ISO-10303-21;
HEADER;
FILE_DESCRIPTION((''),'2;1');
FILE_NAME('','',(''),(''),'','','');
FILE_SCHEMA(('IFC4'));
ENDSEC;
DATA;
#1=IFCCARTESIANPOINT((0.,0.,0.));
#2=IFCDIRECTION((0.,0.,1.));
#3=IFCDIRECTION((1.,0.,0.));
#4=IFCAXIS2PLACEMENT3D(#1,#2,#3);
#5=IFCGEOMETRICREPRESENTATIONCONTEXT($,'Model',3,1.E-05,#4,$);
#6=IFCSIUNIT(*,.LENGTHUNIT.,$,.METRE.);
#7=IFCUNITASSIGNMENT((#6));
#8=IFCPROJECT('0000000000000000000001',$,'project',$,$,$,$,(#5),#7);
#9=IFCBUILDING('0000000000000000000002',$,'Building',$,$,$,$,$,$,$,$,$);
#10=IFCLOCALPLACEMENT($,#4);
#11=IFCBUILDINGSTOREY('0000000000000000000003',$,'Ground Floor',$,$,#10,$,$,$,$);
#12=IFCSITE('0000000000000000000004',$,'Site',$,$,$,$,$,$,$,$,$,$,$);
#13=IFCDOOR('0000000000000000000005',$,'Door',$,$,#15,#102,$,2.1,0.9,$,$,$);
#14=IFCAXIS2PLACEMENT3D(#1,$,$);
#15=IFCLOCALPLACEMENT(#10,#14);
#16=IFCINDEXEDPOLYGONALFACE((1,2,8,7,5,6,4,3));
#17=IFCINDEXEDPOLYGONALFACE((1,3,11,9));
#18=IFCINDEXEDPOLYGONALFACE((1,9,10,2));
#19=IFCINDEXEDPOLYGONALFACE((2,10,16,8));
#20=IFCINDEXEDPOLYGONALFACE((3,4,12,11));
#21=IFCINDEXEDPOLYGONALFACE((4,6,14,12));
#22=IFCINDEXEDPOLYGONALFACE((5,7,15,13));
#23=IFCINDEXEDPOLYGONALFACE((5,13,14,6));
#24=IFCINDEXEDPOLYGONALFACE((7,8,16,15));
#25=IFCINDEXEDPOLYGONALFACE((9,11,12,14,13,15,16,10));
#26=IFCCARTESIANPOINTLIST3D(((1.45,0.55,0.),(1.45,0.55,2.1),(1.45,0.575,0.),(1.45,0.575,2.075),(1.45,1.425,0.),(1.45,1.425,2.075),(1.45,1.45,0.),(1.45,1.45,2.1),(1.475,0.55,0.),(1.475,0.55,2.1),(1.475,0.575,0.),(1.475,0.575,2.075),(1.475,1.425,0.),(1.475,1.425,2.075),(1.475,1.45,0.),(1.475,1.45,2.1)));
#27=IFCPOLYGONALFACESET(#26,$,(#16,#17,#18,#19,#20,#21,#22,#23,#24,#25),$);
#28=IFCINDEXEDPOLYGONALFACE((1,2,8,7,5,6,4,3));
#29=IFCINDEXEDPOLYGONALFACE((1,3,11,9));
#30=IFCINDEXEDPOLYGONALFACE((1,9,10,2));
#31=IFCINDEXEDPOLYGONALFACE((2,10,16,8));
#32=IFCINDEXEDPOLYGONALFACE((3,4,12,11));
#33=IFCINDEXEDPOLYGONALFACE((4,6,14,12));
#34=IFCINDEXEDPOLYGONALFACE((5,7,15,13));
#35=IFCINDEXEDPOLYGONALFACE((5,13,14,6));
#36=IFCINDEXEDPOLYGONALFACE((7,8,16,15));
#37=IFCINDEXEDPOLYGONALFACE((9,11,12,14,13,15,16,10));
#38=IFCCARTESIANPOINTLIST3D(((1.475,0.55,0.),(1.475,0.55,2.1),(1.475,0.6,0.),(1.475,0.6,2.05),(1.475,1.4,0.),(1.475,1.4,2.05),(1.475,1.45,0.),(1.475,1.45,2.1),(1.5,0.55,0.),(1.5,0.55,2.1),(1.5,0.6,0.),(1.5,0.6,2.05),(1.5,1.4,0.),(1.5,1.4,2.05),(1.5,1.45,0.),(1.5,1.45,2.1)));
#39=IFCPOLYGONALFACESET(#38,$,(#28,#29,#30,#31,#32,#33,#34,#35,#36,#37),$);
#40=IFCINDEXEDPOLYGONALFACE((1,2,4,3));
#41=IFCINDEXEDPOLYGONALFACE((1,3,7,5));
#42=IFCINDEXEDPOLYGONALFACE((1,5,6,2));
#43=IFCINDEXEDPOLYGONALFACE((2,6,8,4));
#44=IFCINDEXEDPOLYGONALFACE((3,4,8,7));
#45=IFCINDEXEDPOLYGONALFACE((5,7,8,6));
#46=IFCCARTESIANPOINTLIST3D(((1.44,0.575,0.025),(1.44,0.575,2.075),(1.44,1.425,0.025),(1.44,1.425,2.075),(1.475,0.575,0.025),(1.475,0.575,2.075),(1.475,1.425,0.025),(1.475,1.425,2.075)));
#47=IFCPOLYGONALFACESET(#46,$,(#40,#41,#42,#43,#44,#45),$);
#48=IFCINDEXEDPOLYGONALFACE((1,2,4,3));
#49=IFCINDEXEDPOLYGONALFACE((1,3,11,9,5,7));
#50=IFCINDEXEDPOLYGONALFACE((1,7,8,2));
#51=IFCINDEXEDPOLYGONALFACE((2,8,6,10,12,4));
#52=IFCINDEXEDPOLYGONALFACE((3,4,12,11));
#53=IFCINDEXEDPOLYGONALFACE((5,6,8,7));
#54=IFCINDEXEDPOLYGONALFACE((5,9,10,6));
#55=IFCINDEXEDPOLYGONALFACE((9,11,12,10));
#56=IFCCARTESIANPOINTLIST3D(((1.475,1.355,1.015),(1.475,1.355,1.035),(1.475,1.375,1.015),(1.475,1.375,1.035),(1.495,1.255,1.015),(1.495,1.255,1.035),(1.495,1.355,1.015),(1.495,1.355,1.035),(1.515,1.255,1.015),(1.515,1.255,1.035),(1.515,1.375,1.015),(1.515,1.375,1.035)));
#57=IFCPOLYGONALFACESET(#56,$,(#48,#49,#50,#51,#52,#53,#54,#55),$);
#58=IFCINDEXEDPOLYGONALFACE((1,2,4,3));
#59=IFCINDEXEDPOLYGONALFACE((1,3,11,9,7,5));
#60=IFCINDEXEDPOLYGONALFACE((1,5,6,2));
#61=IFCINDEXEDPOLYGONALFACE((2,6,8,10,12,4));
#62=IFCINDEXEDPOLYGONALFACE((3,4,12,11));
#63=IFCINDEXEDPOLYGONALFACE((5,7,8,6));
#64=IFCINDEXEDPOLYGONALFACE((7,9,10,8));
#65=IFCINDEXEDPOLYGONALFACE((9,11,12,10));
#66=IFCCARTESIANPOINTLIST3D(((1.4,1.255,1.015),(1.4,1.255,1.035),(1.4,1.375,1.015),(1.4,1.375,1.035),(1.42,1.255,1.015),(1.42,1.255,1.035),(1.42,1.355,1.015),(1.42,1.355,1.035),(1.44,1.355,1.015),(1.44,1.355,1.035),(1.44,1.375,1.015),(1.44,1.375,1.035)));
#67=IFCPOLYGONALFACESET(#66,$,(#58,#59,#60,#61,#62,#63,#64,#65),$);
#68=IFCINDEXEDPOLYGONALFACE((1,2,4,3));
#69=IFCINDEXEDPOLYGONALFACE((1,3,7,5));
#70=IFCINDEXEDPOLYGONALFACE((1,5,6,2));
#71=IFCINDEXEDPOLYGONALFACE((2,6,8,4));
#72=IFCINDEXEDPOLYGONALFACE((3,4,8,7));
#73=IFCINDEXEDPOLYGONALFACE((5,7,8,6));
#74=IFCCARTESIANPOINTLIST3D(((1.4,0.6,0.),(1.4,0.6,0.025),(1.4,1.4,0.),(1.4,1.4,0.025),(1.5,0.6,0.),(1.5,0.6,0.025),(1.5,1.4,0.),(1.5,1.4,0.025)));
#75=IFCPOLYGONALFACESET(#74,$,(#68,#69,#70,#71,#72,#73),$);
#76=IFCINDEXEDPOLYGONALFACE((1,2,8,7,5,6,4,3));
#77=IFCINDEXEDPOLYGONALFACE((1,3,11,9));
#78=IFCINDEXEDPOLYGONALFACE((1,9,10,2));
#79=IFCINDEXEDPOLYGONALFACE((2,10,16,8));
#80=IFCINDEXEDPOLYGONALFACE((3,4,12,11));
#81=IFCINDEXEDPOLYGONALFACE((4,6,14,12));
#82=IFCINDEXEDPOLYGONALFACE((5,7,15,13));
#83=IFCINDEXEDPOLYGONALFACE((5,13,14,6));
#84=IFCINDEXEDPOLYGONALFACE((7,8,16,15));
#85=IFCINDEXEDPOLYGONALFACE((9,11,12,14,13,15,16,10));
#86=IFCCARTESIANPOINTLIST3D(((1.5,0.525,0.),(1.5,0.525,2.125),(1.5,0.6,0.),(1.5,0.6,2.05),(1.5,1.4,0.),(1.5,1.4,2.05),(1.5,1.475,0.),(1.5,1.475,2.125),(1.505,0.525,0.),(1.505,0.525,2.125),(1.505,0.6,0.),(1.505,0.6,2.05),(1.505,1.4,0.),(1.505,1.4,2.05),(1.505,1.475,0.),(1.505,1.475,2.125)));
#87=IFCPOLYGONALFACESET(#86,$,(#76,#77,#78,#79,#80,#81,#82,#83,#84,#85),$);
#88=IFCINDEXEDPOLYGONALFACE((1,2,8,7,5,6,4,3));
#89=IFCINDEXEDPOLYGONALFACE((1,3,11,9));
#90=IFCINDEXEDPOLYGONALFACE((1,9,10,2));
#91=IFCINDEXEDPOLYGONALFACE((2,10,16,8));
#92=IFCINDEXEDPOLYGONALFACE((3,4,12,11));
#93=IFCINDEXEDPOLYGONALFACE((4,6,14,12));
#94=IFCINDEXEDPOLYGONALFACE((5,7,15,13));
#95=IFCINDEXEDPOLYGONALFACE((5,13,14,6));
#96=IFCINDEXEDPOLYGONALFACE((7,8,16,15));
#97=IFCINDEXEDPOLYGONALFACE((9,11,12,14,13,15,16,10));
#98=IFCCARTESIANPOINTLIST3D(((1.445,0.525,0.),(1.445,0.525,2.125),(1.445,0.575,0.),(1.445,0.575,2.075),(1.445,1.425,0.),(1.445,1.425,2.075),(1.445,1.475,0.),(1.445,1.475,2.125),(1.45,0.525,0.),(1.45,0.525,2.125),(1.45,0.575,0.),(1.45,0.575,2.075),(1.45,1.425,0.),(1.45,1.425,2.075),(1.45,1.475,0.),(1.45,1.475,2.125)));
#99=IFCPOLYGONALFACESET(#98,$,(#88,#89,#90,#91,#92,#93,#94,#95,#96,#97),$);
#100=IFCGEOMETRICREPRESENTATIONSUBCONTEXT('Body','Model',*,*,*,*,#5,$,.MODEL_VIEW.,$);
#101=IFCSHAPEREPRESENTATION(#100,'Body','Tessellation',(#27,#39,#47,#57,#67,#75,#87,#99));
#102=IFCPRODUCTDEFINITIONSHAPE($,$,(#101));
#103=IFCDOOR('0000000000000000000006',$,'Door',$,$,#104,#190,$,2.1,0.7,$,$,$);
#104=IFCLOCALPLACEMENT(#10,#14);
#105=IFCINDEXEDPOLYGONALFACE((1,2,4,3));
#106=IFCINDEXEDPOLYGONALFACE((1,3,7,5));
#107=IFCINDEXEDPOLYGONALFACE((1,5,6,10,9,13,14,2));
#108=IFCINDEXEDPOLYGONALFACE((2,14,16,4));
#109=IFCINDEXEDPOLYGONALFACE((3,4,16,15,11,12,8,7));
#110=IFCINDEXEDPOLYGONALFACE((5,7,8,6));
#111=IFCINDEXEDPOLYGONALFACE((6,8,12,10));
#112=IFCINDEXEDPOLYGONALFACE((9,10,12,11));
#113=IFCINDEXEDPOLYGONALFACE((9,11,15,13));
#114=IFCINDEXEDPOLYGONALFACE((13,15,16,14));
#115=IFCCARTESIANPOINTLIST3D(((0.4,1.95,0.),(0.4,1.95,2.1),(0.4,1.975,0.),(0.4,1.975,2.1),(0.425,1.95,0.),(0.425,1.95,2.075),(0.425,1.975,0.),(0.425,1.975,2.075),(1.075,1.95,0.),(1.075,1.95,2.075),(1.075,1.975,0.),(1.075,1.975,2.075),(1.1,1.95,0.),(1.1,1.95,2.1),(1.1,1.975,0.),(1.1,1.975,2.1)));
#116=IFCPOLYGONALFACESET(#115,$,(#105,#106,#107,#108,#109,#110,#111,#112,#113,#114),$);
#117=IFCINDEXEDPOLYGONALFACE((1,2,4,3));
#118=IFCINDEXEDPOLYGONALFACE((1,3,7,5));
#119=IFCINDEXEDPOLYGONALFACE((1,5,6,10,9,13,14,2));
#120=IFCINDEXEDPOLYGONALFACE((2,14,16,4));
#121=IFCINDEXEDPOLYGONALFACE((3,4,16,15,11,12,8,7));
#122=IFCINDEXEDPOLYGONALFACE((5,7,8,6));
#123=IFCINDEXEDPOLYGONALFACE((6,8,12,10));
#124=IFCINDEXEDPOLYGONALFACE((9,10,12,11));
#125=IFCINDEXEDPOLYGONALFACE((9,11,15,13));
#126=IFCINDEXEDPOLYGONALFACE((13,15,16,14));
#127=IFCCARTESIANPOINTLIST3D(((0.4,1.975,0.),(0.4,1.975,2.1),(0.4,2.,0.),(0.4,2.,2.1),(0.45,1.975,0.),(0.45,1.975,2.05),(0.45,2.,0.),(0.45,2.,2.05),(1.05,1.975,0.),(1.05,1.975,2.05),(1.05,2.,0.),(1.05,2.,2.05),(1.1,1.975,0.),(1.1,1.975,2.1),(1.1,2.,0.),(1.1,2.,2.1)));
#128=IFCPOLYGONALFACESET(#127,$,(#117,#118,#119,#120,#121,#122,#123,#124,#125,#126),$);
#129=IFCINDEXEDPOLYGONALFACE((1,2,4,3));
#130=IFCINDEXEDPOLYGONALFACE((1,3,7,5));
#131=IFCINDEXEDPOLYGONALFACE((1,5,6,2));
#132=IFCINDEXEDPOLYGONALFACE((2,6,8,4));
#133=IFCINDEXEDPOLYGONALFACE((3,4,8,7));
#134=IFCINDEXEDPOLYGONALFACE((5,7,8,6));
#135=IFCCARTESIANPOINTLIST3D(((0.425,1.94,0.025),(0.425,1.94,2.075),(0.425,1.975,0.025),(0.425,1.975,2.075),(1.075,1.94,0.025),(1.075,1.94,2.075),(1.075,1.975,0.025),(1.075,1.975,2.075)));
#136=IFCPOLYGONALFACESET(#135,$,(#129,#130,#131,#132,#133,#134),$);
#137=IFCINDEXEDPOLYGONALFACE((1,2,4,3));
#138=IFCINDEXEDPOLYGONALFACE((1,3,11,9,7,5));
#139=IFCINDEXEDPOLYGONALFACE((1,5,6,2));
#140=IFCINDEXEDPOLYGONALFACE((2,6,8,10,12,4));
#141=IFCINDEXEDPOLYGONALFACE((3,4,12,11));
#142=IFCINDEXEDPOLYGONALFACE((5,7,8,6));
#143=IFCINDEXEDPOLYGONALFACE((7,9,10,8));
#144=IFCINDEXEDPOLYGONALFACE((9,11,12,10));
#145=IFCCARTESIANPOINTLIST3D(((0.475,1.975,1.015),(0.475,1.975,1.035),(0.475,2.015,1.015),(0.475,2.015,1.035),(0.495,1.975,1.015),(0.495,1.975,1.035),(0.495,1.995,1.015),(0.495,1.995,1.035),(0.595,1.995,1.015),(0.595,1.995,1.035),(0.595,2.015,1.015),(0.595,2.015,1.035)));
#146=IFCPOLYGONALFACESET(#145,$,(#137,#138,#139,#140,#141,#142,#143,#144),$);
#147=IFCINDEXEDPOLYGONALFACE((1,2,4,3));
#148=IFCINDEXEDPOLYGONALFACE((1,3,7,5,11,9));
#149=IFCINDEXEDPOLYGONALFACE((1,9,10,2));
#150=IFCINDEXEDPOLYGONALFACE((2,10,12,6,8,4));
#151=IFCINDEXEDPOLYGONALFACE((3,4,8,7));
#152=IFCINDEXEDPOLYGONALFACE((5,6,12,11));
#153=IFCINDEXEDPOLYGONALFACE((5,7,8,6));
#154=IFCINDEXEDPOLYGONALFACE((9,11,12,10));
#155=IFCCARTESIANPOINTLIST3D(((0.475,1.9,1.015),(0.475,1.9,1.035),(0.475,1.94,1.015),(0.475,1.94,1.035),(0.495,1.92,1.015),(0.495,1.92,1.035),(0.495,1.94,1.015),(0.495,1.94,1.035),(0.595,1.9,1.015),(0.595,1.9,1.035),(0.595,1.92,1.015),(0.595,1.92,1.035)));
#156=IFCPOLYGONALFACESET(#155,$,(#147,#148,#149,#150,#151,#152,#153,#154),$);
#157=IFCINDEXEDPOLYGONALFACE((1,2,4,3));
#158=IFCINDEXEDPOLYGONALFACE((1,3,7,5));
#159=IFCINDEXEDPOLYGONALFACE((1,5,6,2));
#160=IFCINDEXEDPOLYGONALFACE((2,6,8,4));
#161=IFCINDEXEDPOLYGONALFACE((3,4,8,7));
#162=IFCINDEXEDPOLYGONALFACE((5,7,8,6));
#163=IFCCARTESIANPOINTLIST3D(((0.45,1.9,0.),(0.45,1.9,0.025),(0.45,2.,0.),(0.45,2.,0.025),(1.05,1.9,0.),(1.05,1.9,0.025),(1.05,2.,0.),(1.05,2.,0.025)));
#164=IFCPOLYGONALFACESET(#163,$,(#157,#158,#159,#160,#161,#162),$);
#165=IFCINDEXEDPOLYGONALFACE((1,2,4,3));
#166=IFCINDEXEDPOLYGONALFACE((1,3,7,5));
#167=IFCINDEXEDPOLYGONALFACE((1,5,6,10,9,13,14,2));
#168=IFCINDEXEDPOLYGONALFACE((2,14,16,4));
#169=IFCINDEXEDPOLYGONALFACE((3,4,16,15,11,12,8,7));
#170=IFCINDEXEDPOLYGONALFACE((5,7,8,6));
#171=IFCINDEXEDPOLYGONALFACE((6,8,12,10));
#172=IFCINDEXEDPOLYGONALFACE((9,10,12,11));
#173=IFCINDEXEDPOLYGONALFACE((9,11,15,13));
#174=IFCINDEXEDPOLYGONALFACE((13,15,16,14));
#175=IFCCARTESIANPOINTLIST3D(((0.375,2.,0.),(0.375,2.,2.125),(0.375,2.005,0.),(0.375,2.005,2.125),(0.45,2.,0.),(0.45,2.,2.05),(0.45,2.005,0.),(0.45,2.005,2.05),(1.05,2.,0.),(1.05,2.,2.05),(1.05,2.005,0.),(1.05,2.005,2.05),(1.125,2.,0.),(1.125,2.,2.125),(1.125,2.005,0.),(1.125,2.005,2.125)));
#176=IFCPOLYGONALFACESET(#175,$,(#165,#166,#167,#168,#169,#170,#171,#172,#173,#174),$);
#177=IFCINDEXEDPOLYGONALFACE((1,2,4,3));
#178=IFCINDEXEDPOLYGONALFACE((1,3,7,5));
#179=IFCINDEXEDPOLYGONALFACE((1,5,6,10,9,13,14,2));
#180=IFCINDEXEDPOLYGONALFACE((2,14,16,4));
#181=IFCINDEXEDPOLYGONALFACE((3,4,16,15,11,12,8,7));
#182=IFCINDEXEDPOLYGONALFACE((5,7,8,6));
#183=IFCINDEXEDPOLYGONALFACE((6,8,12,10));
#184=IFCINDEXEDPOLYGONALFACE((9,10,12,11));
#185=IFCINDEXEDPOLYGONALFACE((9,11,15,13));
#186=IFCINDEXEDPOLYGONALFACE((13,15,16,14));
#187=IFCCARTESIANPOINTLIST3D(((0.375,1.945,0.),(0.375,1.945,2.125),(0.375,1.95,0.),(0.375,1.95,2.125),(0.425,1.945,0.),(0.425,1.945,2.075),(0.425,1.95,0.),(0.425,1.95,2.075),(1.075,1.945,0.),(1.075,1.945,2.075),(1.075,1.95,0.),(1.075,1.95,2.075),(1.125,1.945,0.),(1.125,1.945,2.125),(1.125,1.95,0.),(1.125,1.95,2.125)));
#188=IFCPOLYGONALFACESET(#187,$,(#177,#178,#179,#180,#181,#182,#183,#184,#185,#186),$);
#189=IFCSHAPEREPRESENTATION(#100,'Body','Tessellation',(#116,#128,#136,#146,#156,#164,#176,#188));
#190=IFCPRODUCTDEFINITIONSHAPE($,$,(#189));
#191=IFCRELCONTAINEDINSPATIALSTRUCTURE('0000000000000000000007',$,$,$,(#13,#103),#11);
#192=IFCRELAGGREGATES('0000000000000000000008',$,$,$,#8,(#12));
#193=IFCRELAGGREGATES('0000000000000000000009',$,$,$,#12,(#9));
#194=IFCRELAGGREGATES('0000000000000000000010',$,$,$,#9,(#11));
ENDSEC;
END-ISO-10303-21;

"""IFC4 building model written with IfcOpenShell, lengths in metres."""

from ifc_helpers import new_model, si_unit, frame, origin_with_axes, place, context, subcontext, project, spatial, line, indexed_curve, outline, extrude, element, save


model = new_model("IFC4")

# Units and contexts
model_context = context("Model", 3, precision=1e-05, world=origin_with_axes())
body_context = subcontext(model_context, "Body", "Model", "MODEL_VIEW")
ifc_project = project(units=[si_unit("LENGTHUNIT", "METRE")], contexts=[model_context])

# Site, building, storey
site = spatial("IfcSite", under=ifc_project, Name="Site")
building = spatial("IfcBuilding", under=site, Name="Building")
storey_placement = place(None, origin_with_axes())
storey = spatial("IfcBuildingStorey", under=building, at=storey_placement, Name="Ground Floor")

# Doors
door_1_placement = place(storey_placement, frame((1.5, 0.55, 0.0), z_axis=(0.0, 0.0, 1.0), x_axis=(0.0, 1.0, 0.0)))
element("IfcDoor", 1, at=door_1_placement, inside=storey, Name="Door", OverallHeight=2.1, OverallWidth=0.9, context=body_context, shape_type="SweptSolid", body=[
    extrude(outline(indexed_curve([(0.0, 0.0), (0.0, 2.1), (0.9, 2.1), (0.9, 0.0), (0.875, 0.0), (0.875, 2.075), (0.025, 2.075), (0.025, 0.0)], segments=[line(1, 2, 3, 4, 5, 6, 7, 8, 1)])), frame((0.0, 0.025, 0.0), z_axis=(0.0, -1.0, 0.0), x_axis=(1.0, 0.0, 0.0)), (0.0, 0.0, -1.0), 0.025),
    extrude(outline(indexed_curve([(0.0, 0.0), (0.0, 2.1), (0.9, 2.1), (0.9, 0.0), (0.85, 0.0), (0.85, 2.05), (0.05, 2.05), (0.05, 0.0)], segments=[line(1, 2, 3, 4, 5, 6, 7, 8, 1)])), frame((0.0, 0.0, 0.0), z_axis=(0.0, -1.0, 0.0), x_axis=(1.0, 0.0, 0.0)), (0.0, 0.0, -1.0), 0.025),
    extrude(outline(indexed_curve([(0.0, 0.0), (0.85, 0.0), (0.85, 0.035), (0.0, 0.035)], segments=[line(1, 2, 3, 4, 1)])), frame((0.025, 0.025, 0.025), z_axis=(0.0, 0.0, 1.0), x_axis=(1.0, 0.0, 0.0)), (0.0, 0.0, 1.0), 2.05),
    extrude(outline(indexed_curve([(0.0, 0.0), (0.0, -0.04), (-0.12, -0.04), (-0.12, -0.02), (-0.02, -0.02), (-0.02, 0.0)], segments=[line(1, 2, 3, 4, 5, 6, 1)])), frame((0.825, 0.025, 1.015), z_axis=(0.0, 0.0, 1.0), x_axis=(1.0, 0.0, 0.0)), (0.0, 0.0, 1.0), 0.02),
    extrude(outline(indexed_curve([(0.0, 0.0), (0.0, 0.04), (-0.12, 0.04), (-0.12, 0.02), (-0.02, 0.02), (-0.02, 0.0)], segments=[line(1, 2, 3, 4, 5, 6, 1)])), frame((0.825, 0.06, 1.015), z_axis=(0.0, 0.0, 1.0), x_axis=(1.0, 0.0, 0.0)), (0.0, 0.0, 1.0), 0.02),
    extrude(outline(indexed_curve([(0.0, 0.0), (0.8, 0.0), (0.8, 0.1), (0.0, 0.1)], segments=[line(1, 2, 3, 4, 1)])), frame((0.05, 0.0, 0.0), z_axis=(0.0, 0.0, 1.0), x_axis=(1.0, 0.0, 0.0)), (0.0, 0.0, 1.0), 0.025),
    extrude(outline(indexed_curve([(0.0, 0.0), (0.0, 2.125), (0.95, 2.125), (0.95, 0.0), (0.875, 0.0), (0.875, 2.05), (0.075, 2.05), (0.075, 0.0)], segments=[line(1, 2, 3, 4, 5, 6, 7, 8, 1)])), frame((-0.025, -0.005, 0.0), z_axis=(0.0, -1.0, 0.0), x_axis=(1.0, 0.0, 0.0)), (0.0, 0.0, -1.0), 0.005),
    extrude(outline(indexed_curve([(0.0, 0.0), (0.0, 2.125), (0.95, 2.125), (0.95, 0.0), (0.9, 0.0), (0.9, 2.075), (0.05, 2.075), (0.05, 0.0)], segments=[line(1, 2, 3, 4, 5, 6, 7, 8, 1)])), frame((-0.025, 0.05, 0.0), z_axis=(0.0, -1.0, 0.0), x_axis=(1.0, 0.0, 0.0)), (0.0, 0.0, -1.0), 0.005),
])
door_2_placement = place(storey_placement, frame((1.1, 2.0, 0.0), z_axis=(0.0, 0.0, 1.0), x_axis=(-1.0, 0.0, 0.0)))
element("IfcDoor", 2, at=door_2_placement, inside=storey, Name="Door", OverallHeight=2.1, OverallWidth=0.7, context=body_context, shape_type="SweptSolid", body=[
    extrude(outline(indexed_curve([(0.0, 0.0), (0.0, 2.1), (0.7, 2.1), (0.7, 0.0), (0.675, 0.0), (0.675, 2.075), (0.025, 2.075), (0.025, 0.0)], segments=[line(1, 2, 3, 4, 5, 6, 7, 8, 1)])), frame((0.0, 0.025, 0.0), z_axis=(0.0, -1.0, 0.0), x_axis=(1.0, 0.0, 0.0)), (0.0, 0.0, -1.0), 0.025),
    extrude(outline(indexed_curve([(0.0, 0.0), (0.0, 2.1), (0.7, 2.1), (0.7, 0.0), (0.65, 0.0), (0.65, 2.05), (0.05, 2.05), (0.05, 0.0)], segments=[line(1, 2, 3, 4, 5, 6, 7, 8, 1)])), frame((0.0, 0.0, 0.0), z_axis=(0.0, -1.0, 0.0), x_axis=(1.0, 0.0, 0.0)), (0.0, 0.0, -1.0), 0.025),
    extrude(outline(indexed_curve([(0.0, 0.0), (0.65, 0.0), (0.65, 0.035), (0.0, 0.035)], segments=[line(1, 2, 3, 4, 1)])), frame((0.025, 0.025, 0.025), z_axis=(0.0, 0.0, 1.0), x_axis=(1.0, 0.0, 0.0)), (0.0, 0.0, 1.0), 2.05),
    extrude(outline(indexed_curve([(0.0, 0.0), (0.0, -0.04), (-0.12, -0.04), (-0.12, -0.02), (-0.02, -0.02), (-0.02, 0.0)], segments=[line(1, 2, 3, 4, 5, 6, 1)])), frame((0.625, 0.025, 1.015), z_axis=(0.0, 0.0, 1.0), x_axis=(1.0, 0.0, 0.0)), (0.0, 0.0, 1.0), 0.02),
    extrude(outline(indexed_curve([(0.0, 0.0), (0.0, 0.04), (-0.12, 0.04), (-0.12, 0.02), (-0.02, 0.02), (-0.02, 0.0)], segments=[line(1, 2, 3, 4, 5, 6, 1)])), frame((0.625, 0.06, 1.015), z_axis=(0.0, 0.0, 1.0), x_axis=(1.0, 0.0, 0.0)), (0.0, 0.0, 1.0), 0.02),
    extrude(outline(indexed_curve([(0.0, 0.0), (0.6, 0.0), (0.6, 0.1), (0.0, 0.1)], segments=[line(1, 2, 3, 4, 1)])), frame((0.05, 0.0, 0.0), z_axis=(0.0, 0.0, 1.0), x_axis=(1.0, 0.0, 0.0)), (0.0, 0.0, 1.0), 0.025),
    extrude(outline(indexed_curve([(0.0, 0.0), (0.0, 2.125), (0.75, 2.125), (0.75, 0.0), (0.675, 0.0), (0.675, 2.05), (0.075, 2.05), (0.075, 0.0)], segments=[line(1, 2, 3, 4, 5, 6, 7, 8, 1)])), frame((-0.025, -0.005, 0.0), z_axis=(0.0, -1.0, 0.0), x_axis=(1.0, 0.0, 0.0)), (0.0, 0.0, -1.0), 0.005),
    extrude(outline(indexed_curve([(0.0, 0.0), (0.0, 2.125), (0.75, 2.125), (0.75, 0.0), (0.7, 0.0), (0.7, 2.075), (0.05, 2.075), (0.05, 0.0)], segments=[line(1, 2, 3, 4, 5, 6, 7, 8, 1)])), frame((-0.025, 0.05, 0.0), z_axis=(0.0, -1.0, 0.0), x_axis=(1.0, 0.0, 0.0)), (0.0, 0.0, -1.0), 0.005),
])

save(model, "model.ifc")
